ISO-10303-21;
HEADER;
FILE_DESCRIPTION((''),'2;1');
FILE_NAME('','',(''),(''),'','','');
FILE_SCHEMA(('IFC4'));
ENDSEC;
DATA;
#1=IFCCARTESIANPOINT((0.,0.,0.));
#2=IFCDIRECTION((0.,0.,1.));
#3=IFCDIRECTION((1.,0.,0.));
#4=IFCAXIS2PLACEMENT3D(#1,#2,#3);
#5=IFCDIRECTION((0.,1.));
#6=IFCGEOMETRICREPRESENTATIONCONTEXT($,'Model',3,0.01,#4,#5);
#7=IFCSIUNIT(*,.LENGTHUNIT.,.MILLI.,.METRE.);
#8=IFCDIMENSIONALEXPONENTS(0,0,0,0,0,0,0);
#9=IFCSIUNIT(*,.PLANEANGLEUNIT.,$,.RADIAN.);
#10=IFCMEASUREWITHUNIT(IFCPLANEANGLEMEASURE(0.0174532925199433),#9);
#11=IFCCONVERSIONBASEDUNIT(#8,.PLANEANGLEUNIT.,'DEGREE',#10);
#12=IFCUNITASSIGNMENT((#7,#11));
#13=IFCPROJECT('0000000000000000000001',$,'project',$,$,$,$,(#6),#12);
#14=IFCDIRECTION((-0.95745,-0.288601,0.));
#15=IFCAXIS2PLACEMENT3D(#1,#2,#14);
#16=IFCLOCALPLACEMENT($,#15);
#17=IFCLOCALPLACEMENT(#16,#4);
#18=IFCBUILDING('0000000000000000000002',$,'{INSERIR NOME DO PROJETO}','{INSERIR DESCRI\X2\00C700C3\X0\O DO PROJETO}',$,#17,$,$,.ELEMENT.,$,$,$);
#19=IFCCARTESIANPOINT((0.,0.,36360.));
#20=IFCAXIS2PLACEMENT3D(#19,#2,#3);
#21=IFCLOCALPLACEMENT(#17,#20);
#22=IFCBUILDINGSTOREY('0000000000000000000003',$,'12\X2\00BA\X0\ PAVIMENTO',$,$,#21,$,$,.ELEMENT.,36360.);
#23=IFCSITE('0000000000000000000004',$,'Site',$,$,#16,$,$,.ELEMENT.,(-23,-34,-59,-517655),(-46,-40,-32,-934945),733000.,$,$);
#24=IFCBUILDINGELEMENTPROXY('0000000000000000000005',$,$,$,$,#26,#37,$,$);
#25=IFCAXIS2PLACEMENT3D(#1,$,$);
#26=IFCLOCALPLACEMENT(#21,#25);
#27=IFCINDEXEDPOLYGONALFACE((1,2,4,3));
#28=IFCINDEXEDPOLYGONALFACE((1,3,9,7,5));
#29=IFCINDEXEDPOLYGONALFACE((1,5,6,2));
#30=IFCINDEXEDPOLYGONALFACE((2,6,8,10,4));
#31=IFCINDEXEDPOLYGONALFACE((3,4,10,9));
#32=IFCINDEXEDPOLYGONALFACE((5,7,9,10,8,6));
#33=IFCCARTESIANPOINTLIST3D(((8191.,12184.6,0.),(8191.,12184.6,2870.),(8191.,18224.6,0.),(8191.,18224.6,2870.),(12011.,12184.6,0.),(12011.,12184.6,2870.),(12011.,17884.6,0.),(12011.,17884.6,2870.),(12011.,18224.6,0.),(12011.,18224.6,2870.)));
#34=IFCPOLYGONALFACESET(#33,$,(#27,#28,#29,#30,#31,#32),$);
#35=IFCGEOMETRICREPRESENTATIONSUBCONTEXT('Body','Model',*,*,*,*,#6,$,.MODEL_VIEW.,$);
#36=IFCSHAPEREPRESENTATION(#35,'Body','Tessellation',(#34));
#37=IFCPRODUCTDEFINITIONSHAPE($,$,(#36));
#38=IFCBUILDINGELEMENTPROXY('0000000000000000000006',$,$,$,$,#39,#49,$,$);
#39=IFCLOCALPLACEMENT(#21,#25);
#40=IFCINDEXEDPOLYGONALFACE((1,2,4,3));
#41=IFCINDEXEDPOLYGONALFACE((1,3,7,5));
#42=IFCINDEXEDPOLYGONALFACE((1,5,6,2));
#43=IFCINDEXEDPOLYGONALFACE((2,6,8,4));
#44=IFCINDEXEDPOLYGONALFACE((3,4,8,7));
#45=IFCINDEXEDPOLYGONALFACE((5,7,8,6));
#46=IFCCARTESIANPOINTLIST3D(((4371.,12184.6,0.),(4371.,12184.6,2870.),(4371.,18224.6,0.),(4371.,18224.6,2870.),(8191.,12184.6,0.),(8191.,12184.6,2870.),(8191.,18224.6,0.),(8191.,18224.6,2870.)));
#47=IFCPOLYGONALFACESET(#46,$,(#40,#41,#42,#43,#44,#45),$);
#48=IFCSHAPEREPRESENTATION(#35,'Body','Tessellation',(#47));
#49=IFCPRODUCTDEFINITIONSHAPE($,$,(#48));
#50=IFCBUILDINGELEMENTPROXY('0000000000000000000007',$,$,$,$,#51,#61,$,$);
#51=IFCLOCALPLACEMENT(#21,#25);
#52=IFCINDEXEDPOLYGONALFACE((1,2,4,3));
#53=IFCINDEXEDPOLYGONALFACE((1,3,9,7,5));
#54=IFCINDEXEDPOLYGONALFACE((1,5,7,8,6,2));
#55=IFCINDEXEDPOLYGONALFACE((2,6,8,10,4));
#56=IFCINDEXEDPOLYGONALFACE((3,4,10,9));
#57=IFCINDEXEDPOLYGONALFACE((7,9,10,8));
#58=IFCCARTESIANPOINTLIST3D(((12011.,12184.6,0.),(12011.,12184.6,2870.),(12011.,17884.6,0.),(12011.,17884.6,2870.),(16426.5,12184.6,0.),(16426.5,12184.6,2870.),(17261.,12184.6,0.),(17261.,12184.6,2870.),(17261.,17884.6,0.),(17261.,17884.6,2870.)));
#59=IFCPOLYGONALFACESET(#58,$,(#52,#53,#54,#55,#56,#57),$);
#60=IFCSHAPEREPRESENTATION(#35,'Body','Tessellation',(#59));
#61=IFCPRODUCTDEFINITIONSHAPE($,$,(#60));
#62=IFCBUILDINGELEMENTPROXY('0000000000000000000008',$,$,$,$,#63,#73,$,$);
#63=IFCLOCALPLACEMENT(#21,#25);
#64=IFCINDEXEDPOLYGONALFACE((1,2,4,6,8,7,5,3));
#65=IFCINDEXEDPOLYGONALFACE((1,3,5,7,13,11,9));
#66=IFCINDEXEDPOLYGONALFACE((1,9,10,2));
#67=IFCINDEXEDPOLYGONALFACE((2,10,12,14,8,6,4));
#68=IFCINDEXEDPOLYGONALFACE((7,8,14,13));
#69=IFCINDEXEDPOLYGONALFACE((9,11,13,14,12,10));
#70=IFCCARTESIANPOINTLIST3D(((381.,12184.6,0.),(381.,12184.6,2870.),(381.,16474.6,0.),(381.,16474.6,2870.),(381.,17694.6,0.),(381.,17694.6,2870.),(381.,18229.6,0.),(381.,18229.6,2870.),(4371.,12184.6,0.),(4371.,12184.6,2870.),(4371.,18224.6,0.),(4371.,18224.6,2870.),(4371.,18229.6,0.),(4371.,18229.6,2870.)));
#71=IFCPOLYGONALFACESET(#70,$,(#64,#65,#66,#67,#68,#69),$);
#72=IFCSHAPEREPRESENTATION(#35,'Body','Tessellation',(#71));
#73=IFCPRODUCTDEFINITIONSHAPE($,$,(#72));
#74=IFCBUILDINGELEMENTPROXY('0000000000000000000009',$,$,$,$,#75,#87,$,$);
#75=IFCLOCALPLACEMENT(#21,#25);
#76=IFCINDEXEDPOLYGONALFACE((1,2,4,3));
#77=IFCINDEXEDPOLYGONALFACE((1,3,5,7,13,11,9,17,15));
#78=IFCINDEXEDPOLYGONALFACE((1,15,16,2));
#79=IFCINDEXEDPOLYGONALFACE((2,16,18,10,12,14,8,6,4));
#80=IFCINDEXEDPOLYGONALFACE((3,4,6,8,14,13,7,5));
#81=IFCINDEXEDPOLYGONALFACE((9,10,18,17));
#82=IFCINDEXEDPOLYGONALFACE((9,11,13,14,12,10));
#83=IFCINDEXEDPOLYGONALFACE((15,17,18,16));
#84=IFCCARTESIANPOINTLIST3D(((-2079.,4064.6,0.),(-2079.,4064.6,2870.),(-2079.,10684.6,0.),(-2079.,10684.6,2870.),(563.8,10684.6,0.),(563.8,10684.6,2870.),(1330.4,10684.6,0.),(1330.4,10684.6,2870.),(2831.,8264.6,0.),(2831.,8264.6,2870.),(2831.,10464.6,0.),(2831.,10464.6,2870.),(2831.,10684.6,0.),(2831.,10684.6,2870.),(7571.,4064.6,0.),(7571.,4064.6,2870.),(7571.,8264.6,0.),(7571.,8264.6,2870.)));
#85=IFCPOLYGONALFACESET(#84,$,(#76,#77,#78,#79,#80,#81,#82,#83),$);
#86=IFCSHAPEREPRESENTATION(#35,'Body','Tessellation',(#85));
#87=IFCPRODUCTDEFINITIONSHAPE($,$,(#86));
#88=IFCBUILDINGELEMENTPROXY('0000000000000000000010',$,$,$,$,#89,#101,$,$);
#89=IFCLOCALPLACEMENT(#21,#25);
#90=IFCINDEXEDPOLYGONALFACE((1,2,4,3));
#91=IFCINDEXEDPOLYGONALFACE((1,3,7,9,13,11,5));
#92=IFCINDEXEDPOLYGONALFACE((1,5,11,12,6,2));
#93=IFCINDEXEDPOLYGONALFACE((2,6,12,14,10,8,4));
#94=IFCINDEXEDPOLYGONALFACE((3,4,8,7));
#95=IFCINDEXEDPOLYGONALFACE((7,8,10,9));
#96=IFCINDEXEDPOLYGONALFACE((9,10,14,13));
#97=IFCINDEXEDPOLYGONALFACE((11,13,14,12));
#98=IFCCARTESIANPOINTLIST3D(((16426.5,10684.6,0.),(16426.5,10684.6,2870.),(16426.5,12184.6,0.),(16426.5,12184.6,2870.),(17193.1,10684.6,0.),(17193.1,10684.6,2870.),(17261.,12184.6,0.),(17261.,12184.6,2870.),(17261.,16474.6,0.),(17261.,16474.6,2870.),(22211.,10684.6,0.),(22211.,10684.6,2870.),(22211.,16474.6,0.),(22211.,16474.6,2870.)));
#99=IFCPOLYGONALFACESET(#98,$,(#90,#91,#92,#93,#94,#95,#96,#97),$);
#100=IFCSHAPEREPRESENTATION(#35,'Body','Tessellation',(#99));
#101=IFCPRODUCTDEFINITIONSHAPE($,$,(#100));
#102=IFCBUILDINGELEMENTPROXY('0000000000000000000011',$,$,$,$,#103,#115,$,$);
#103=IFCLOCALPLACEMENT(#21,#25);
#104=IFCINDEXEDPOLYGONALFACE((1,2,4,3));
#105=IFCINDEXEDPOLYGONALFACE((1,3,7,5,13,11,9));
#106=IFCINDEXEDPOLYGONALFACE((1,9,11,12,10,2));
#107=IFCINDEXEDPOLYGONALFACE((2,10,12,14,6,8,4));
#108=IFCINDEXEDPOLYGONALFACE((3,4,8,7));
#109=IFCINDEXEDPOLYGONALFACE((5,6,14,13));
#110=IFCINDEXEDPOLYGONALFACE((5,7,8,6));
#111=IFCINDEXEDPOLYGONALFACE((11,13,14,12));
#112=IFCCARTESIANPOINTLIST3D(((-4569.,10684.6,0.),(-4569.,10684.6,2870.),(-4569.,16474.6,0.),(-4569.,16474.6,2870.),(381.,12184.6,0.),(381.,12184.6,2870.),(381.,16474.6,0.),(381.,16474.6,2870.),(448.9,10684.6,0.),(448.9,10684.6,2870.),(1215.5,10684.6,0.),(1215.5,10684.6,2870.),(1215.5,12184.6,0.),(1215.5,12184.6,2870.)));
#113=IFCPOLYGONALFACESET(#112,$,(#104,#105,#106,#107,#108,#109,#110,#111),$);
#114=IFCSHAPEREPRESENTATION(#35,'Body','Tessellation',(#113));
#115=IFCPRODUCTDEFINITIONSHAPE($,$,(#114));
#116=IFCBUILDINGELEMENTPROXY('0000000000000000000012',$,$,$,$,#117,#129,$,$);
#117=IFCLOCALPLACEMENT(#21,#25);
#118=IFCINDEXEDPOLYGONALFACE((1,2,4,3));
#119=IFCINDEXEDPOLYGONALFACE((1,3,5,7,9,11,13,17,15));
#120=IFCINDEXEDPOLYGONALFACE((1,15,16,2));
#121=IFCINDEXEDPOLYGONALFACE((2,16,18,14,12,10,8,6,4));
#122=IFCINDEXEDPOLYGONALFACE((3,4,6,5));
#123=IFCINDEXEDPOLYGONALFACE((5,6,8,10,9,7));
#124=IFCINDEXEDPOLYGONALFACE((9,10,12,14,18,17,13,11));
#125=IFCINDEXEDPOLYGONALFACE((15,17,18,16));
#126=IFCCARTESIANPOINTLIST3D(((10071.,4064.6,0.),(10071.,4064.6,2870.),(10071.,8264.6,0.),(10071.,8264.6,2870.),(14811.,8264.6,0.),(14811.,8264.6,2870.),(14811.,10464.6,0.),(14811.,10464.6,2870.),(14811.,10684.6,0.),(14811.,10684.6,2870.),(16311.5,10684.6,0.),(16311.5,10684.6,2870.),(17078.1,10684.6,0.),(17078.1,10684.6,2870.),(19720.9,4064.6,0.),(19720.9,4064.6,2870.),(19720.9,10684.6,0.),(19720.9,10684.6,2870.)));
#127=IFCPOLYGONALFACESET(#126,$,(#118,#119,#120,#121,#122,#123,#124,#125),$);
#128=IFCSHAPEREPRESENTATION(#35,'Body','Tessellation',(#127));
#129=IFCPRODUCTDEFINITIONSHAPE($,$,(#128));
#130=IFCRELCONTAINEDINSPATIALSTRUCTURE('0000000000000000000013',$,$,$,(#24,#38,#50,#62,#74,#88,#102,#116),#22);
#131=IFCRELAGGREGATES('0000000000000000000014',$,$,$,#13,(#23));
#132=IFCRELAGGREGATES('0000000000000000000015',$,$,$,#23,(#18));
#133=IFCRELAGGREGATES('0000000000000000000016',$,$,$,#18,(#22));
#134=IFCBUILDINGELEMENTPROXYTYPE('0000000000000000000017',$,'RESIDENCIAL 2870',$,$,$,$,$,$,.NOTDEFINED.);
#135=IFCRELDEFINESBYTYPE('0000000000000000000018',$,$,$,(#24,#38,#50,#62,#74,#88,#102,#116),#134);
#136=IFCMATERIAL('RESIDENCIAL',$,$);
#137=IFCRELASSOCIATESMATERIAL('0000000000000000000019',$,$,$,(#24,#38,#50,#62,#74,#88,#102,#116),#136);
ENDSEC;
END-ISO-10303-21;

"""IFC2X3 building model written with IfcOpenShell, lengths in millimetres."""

from ifc_helpers import new_model, entity, si_unit, converted_unit, direction, frame, origin_with_axes, place, context, subcontext, project, spatial, polyline, outline, extrude, material, type_object, element, save


model = new_model("IFC2X3")

# Units and contexts
model_context = context("Model", 3, precision=0.01, world=origin_with_axes(), true_north=direction((0.0, 1.0)))
body_context = subcontext(model_context, "Body", "Model", "MODEL_VIEW")
ifc_project = project(units=[si_unit("LENGTHUNIT", "METRE", prefix="MILLI"), converted_unit("PLANEANGLEUNIT", "DEGREE", entity("IfcPlaneAngleMeasure", 0.0174532925199433), si_unit("PLANEANGLEUNIT", "RADIAN"), dimensions=[0, 0, 0, 0, 0, 0, 0])], contexts=[model_context])

# Site, building, storey
site_placement = place(None, frame((0.0, 0.0, 0.0), z_axis=(0.0, 0.0, 1.0), x_axis=(-0.95745, -0.288601, 0.0)))
site = spatial("IfcSite", under=ifc_project, at=site_placement, Name="Site", CompositionType="ELEMENT", RefLatitude=(-23, -34, -59, -517655), RefLongitude=(-46, -40, -32, -934945), RefElevation=733000.0)
building_placement = place(site_placement, origin_with_axes())
building = spatial("IfcBuilding", under=site, at=building_placement, Name="{INSERIR NOME DO PROJETO}", Description="{INSERIR DESCRIÇÃO DO PROJETO}", CompositionType="ELEMENT")
storey_placement = place(building_placement, frame((0.0, 0.0, 36360.0), z_axis=(0.0, 0.0, 1.0), x_axis=(1.0, 0.0, 0.0)))
storey = spatial("IfcBuildingStorey", under=building, at=storey_placement, Name="12º PAVIMENTO", CompositionType="ELEMENT", Elevation=36360.0)

# Building element proxies
ifc_material_1 = material(Name="RESIDENCIAL")
building_element_proxy_type_1 = type_object("IfcBuildingElementProxyType", Name="RESIDENCIAL 2870", PredefinedType="NOTDEFINED")
proxy_1_placement = place(storey_placement, frame((8191.0, 18224.6, 0.0), z_axis=(0.0, 0.0, 1.0), x_axis=(1.0, 0.0, 0.0)))
element("IfcBuildingElementProxy", 1, at=proxy_1_placement, inside=storey, type_object=building_element_proxy_type_1, material=ifc_material_1, context=body_context, shape_type="SweptSolid", body=[
    extrude(outline(polyline([(0.0, 0.0), (0.0, -6040.0), (3820.0, -6040.0), (3820.0, -340.0), (3820.0, 0.0), (0.0, 0.0)])), origin_with_axes(), (0.0, 0.0, 1.0), 2870.0),
])
proxy_2_placement = place(storey_placement, frame((4371.0, 18224.6, 0.0), z_axis=(0.0, 0.0, 1.0), x_axis=(1.0, 0.0, 0.0)))
element("IfcBuildingElementProxy", 2, at=proxy_2_placement, inside=storey, type_object=building_element_proxy_type_1, material=ifc_material_1, context=body_context, shape_type="SweptSolid", body=[
    extrude(outline(polyline([(0.0, 0.0), (0.0, -6040.0), (3820.0, -6040.0), (3820.0, 0.0), (0.0, 0.0)])), origin_with_axes(), (0.0, 0.0, 1.0), 2870.0),
])
proxy_3_placement = place(storey_placement, frame((12011.0, 12184.6, 0.0), z_axis=(0.0, 0.0, 1.0), x_axis=(1.0, 0.0, 0.0)))
element("IfcBuildingElementProxy", 3, at=proxy_3_placement, inside=storey, type_object=building_element_proxy_type_1, material=ifc_material_1, context=body_context, shape_type="SweptSolid", body=[
    extrude(outline(polyline([(0.0, 0.0), (4415.5, 0.0), (5250.0, 0.0), (5250.0, 5700.0), (0.0, 5700.0), (0.0, 0.0)])), origin_with_axes(), (0.0, 0.0, 1.0), 2870.0),
])
proxy_4_placement = place(storey_placement, frame((381.0, 16474.6, 0.0), z_axis=(0.0, 0.0, 1.0), x_axis=(1.0, 0.0, 0.0)))
element("IfcBuildingElementProxy", 4, at=proxy_4_placement, inside=storey, type_object=building_element_proxy_type_1, material=ifc_material_1, context=body_context, shape_type="SweptSolid", body=[
    extrude(outline(polyline([(0.0, 0.0), (0.0, -4290.0), (3990.0, -4290.0), (3990.0, 1750.0), (3990.0, 1755.0), (0.0, 1755.0), (0.0, 1220.0), (0.0, 0.0)])), origin_with_axes(), (0.0, 0.0, 1.0), 2870.0),
])
proxy_5_placement = place(storey_placement, frame((-2079.0, 4064.6, 0.0), z_axis=(0.0, 0.0, 1.0), x_axis=(1.0, 0.0, 0.0)))
element("IfcBuildingElementProxy", 5, at=proxy_5_placement, inside=storey, type_object=building_element_proxy_type_1, material=ifc_material_1, context=body_context, shape_type="SweptSolid", body=[
    extrude(outline(polyline([(0.0, 0.0), (9650.0, 0.0), (9650.0, 4200.0), (4910.0, 4200.0), (4910.0, 6400.0), (4910.0, 6620.0), (3409.4, 6620.0), (2642.8, 6620.0), (0.0, 6620.0), (0.0, 0.0)])), origin_with_axes(), (0.0, 0.0, 1.0), 2870.0),
])
proxy_6_placement = place(storey_placement, frame((17261.0, 12184.6, 0.0), z_axis=(0.0, 0.0, 1.0), x_axis=(1.0, 0.0, 0.0)))
element("IfcBuildingElementProxy", 6, at=proxy_6_placement, inside=storey, type_object=building_element_proxy_type_1, material=ifc_material_1, context=body_context, shape_type="SweptSolid", body=[
    extrude(outline(polyline([(0.0, 0.0), (-834.5, 0.0), (-834.5, -1500.0), (-67.9, -1500.0), (4950.0, -1500.0), (4950.0, 4290.0), (0.0, 4290.0), (0.0, 0.0)])), origin_with_axes(), (0.0, 0.0, 1.0), 2870.0),
])
proxy_7_placement = place(storey_placement, frame((-4569.0, 16474.6, 0.0), z_axis=(0.0, 0.0, 1.0), x_axis=(1.0, 0.0, 0.0)))
element("IfcBuildingElementProxy", 7, at=proxy_7_placement, inside=storey, type_object=building_element_proxy_type_1, material=ifc_material_1, context=body_context, shape_type="SweptSolid", body=[
    extrude(outline(polyline([(0.0, 0.0), (0.0, -5790.0), (5017.9, -5790.0), (5784.5, -5790.0), (5784.5, -4290.0), (4950.0, -4290.0), (4950.0, 0.0), (0.0, 0.0)])), origin_with_axes(), (0.0, 0.0, 1.0), 2870.0),
])
proxy_8_placement = place(storey_placement, frame((19720.9, 4064.6, 0.0), z_axis=(0.0, 0.0, 1.0), x_axis=(1.0, 0.0, 0.0)))
element("IfcBuildingElementProxy", 8, at=proxy_8_placement, inside=storey, type_object=building_element_proxy_type_1, material=ifc_material_1, context=body_context, shape_type="SweptSolid", body=[
    extrude(outline(polyline([(0.0, 0.0), (0.0, 6620.0), (-2642.8, 6620.0), (-3409.4, 6620.0), (-4910.0, 6620.0), (-4910.0, 6400.0), (-4910.0, 4200.0), (-9650.0, 4200.0), (-9650.0, 0.0), (0.0, 0.0)])), origin_with_axes(), (0.0, 0.0, 1.0), 2870.0),
])

save(model, "model.ifc")
